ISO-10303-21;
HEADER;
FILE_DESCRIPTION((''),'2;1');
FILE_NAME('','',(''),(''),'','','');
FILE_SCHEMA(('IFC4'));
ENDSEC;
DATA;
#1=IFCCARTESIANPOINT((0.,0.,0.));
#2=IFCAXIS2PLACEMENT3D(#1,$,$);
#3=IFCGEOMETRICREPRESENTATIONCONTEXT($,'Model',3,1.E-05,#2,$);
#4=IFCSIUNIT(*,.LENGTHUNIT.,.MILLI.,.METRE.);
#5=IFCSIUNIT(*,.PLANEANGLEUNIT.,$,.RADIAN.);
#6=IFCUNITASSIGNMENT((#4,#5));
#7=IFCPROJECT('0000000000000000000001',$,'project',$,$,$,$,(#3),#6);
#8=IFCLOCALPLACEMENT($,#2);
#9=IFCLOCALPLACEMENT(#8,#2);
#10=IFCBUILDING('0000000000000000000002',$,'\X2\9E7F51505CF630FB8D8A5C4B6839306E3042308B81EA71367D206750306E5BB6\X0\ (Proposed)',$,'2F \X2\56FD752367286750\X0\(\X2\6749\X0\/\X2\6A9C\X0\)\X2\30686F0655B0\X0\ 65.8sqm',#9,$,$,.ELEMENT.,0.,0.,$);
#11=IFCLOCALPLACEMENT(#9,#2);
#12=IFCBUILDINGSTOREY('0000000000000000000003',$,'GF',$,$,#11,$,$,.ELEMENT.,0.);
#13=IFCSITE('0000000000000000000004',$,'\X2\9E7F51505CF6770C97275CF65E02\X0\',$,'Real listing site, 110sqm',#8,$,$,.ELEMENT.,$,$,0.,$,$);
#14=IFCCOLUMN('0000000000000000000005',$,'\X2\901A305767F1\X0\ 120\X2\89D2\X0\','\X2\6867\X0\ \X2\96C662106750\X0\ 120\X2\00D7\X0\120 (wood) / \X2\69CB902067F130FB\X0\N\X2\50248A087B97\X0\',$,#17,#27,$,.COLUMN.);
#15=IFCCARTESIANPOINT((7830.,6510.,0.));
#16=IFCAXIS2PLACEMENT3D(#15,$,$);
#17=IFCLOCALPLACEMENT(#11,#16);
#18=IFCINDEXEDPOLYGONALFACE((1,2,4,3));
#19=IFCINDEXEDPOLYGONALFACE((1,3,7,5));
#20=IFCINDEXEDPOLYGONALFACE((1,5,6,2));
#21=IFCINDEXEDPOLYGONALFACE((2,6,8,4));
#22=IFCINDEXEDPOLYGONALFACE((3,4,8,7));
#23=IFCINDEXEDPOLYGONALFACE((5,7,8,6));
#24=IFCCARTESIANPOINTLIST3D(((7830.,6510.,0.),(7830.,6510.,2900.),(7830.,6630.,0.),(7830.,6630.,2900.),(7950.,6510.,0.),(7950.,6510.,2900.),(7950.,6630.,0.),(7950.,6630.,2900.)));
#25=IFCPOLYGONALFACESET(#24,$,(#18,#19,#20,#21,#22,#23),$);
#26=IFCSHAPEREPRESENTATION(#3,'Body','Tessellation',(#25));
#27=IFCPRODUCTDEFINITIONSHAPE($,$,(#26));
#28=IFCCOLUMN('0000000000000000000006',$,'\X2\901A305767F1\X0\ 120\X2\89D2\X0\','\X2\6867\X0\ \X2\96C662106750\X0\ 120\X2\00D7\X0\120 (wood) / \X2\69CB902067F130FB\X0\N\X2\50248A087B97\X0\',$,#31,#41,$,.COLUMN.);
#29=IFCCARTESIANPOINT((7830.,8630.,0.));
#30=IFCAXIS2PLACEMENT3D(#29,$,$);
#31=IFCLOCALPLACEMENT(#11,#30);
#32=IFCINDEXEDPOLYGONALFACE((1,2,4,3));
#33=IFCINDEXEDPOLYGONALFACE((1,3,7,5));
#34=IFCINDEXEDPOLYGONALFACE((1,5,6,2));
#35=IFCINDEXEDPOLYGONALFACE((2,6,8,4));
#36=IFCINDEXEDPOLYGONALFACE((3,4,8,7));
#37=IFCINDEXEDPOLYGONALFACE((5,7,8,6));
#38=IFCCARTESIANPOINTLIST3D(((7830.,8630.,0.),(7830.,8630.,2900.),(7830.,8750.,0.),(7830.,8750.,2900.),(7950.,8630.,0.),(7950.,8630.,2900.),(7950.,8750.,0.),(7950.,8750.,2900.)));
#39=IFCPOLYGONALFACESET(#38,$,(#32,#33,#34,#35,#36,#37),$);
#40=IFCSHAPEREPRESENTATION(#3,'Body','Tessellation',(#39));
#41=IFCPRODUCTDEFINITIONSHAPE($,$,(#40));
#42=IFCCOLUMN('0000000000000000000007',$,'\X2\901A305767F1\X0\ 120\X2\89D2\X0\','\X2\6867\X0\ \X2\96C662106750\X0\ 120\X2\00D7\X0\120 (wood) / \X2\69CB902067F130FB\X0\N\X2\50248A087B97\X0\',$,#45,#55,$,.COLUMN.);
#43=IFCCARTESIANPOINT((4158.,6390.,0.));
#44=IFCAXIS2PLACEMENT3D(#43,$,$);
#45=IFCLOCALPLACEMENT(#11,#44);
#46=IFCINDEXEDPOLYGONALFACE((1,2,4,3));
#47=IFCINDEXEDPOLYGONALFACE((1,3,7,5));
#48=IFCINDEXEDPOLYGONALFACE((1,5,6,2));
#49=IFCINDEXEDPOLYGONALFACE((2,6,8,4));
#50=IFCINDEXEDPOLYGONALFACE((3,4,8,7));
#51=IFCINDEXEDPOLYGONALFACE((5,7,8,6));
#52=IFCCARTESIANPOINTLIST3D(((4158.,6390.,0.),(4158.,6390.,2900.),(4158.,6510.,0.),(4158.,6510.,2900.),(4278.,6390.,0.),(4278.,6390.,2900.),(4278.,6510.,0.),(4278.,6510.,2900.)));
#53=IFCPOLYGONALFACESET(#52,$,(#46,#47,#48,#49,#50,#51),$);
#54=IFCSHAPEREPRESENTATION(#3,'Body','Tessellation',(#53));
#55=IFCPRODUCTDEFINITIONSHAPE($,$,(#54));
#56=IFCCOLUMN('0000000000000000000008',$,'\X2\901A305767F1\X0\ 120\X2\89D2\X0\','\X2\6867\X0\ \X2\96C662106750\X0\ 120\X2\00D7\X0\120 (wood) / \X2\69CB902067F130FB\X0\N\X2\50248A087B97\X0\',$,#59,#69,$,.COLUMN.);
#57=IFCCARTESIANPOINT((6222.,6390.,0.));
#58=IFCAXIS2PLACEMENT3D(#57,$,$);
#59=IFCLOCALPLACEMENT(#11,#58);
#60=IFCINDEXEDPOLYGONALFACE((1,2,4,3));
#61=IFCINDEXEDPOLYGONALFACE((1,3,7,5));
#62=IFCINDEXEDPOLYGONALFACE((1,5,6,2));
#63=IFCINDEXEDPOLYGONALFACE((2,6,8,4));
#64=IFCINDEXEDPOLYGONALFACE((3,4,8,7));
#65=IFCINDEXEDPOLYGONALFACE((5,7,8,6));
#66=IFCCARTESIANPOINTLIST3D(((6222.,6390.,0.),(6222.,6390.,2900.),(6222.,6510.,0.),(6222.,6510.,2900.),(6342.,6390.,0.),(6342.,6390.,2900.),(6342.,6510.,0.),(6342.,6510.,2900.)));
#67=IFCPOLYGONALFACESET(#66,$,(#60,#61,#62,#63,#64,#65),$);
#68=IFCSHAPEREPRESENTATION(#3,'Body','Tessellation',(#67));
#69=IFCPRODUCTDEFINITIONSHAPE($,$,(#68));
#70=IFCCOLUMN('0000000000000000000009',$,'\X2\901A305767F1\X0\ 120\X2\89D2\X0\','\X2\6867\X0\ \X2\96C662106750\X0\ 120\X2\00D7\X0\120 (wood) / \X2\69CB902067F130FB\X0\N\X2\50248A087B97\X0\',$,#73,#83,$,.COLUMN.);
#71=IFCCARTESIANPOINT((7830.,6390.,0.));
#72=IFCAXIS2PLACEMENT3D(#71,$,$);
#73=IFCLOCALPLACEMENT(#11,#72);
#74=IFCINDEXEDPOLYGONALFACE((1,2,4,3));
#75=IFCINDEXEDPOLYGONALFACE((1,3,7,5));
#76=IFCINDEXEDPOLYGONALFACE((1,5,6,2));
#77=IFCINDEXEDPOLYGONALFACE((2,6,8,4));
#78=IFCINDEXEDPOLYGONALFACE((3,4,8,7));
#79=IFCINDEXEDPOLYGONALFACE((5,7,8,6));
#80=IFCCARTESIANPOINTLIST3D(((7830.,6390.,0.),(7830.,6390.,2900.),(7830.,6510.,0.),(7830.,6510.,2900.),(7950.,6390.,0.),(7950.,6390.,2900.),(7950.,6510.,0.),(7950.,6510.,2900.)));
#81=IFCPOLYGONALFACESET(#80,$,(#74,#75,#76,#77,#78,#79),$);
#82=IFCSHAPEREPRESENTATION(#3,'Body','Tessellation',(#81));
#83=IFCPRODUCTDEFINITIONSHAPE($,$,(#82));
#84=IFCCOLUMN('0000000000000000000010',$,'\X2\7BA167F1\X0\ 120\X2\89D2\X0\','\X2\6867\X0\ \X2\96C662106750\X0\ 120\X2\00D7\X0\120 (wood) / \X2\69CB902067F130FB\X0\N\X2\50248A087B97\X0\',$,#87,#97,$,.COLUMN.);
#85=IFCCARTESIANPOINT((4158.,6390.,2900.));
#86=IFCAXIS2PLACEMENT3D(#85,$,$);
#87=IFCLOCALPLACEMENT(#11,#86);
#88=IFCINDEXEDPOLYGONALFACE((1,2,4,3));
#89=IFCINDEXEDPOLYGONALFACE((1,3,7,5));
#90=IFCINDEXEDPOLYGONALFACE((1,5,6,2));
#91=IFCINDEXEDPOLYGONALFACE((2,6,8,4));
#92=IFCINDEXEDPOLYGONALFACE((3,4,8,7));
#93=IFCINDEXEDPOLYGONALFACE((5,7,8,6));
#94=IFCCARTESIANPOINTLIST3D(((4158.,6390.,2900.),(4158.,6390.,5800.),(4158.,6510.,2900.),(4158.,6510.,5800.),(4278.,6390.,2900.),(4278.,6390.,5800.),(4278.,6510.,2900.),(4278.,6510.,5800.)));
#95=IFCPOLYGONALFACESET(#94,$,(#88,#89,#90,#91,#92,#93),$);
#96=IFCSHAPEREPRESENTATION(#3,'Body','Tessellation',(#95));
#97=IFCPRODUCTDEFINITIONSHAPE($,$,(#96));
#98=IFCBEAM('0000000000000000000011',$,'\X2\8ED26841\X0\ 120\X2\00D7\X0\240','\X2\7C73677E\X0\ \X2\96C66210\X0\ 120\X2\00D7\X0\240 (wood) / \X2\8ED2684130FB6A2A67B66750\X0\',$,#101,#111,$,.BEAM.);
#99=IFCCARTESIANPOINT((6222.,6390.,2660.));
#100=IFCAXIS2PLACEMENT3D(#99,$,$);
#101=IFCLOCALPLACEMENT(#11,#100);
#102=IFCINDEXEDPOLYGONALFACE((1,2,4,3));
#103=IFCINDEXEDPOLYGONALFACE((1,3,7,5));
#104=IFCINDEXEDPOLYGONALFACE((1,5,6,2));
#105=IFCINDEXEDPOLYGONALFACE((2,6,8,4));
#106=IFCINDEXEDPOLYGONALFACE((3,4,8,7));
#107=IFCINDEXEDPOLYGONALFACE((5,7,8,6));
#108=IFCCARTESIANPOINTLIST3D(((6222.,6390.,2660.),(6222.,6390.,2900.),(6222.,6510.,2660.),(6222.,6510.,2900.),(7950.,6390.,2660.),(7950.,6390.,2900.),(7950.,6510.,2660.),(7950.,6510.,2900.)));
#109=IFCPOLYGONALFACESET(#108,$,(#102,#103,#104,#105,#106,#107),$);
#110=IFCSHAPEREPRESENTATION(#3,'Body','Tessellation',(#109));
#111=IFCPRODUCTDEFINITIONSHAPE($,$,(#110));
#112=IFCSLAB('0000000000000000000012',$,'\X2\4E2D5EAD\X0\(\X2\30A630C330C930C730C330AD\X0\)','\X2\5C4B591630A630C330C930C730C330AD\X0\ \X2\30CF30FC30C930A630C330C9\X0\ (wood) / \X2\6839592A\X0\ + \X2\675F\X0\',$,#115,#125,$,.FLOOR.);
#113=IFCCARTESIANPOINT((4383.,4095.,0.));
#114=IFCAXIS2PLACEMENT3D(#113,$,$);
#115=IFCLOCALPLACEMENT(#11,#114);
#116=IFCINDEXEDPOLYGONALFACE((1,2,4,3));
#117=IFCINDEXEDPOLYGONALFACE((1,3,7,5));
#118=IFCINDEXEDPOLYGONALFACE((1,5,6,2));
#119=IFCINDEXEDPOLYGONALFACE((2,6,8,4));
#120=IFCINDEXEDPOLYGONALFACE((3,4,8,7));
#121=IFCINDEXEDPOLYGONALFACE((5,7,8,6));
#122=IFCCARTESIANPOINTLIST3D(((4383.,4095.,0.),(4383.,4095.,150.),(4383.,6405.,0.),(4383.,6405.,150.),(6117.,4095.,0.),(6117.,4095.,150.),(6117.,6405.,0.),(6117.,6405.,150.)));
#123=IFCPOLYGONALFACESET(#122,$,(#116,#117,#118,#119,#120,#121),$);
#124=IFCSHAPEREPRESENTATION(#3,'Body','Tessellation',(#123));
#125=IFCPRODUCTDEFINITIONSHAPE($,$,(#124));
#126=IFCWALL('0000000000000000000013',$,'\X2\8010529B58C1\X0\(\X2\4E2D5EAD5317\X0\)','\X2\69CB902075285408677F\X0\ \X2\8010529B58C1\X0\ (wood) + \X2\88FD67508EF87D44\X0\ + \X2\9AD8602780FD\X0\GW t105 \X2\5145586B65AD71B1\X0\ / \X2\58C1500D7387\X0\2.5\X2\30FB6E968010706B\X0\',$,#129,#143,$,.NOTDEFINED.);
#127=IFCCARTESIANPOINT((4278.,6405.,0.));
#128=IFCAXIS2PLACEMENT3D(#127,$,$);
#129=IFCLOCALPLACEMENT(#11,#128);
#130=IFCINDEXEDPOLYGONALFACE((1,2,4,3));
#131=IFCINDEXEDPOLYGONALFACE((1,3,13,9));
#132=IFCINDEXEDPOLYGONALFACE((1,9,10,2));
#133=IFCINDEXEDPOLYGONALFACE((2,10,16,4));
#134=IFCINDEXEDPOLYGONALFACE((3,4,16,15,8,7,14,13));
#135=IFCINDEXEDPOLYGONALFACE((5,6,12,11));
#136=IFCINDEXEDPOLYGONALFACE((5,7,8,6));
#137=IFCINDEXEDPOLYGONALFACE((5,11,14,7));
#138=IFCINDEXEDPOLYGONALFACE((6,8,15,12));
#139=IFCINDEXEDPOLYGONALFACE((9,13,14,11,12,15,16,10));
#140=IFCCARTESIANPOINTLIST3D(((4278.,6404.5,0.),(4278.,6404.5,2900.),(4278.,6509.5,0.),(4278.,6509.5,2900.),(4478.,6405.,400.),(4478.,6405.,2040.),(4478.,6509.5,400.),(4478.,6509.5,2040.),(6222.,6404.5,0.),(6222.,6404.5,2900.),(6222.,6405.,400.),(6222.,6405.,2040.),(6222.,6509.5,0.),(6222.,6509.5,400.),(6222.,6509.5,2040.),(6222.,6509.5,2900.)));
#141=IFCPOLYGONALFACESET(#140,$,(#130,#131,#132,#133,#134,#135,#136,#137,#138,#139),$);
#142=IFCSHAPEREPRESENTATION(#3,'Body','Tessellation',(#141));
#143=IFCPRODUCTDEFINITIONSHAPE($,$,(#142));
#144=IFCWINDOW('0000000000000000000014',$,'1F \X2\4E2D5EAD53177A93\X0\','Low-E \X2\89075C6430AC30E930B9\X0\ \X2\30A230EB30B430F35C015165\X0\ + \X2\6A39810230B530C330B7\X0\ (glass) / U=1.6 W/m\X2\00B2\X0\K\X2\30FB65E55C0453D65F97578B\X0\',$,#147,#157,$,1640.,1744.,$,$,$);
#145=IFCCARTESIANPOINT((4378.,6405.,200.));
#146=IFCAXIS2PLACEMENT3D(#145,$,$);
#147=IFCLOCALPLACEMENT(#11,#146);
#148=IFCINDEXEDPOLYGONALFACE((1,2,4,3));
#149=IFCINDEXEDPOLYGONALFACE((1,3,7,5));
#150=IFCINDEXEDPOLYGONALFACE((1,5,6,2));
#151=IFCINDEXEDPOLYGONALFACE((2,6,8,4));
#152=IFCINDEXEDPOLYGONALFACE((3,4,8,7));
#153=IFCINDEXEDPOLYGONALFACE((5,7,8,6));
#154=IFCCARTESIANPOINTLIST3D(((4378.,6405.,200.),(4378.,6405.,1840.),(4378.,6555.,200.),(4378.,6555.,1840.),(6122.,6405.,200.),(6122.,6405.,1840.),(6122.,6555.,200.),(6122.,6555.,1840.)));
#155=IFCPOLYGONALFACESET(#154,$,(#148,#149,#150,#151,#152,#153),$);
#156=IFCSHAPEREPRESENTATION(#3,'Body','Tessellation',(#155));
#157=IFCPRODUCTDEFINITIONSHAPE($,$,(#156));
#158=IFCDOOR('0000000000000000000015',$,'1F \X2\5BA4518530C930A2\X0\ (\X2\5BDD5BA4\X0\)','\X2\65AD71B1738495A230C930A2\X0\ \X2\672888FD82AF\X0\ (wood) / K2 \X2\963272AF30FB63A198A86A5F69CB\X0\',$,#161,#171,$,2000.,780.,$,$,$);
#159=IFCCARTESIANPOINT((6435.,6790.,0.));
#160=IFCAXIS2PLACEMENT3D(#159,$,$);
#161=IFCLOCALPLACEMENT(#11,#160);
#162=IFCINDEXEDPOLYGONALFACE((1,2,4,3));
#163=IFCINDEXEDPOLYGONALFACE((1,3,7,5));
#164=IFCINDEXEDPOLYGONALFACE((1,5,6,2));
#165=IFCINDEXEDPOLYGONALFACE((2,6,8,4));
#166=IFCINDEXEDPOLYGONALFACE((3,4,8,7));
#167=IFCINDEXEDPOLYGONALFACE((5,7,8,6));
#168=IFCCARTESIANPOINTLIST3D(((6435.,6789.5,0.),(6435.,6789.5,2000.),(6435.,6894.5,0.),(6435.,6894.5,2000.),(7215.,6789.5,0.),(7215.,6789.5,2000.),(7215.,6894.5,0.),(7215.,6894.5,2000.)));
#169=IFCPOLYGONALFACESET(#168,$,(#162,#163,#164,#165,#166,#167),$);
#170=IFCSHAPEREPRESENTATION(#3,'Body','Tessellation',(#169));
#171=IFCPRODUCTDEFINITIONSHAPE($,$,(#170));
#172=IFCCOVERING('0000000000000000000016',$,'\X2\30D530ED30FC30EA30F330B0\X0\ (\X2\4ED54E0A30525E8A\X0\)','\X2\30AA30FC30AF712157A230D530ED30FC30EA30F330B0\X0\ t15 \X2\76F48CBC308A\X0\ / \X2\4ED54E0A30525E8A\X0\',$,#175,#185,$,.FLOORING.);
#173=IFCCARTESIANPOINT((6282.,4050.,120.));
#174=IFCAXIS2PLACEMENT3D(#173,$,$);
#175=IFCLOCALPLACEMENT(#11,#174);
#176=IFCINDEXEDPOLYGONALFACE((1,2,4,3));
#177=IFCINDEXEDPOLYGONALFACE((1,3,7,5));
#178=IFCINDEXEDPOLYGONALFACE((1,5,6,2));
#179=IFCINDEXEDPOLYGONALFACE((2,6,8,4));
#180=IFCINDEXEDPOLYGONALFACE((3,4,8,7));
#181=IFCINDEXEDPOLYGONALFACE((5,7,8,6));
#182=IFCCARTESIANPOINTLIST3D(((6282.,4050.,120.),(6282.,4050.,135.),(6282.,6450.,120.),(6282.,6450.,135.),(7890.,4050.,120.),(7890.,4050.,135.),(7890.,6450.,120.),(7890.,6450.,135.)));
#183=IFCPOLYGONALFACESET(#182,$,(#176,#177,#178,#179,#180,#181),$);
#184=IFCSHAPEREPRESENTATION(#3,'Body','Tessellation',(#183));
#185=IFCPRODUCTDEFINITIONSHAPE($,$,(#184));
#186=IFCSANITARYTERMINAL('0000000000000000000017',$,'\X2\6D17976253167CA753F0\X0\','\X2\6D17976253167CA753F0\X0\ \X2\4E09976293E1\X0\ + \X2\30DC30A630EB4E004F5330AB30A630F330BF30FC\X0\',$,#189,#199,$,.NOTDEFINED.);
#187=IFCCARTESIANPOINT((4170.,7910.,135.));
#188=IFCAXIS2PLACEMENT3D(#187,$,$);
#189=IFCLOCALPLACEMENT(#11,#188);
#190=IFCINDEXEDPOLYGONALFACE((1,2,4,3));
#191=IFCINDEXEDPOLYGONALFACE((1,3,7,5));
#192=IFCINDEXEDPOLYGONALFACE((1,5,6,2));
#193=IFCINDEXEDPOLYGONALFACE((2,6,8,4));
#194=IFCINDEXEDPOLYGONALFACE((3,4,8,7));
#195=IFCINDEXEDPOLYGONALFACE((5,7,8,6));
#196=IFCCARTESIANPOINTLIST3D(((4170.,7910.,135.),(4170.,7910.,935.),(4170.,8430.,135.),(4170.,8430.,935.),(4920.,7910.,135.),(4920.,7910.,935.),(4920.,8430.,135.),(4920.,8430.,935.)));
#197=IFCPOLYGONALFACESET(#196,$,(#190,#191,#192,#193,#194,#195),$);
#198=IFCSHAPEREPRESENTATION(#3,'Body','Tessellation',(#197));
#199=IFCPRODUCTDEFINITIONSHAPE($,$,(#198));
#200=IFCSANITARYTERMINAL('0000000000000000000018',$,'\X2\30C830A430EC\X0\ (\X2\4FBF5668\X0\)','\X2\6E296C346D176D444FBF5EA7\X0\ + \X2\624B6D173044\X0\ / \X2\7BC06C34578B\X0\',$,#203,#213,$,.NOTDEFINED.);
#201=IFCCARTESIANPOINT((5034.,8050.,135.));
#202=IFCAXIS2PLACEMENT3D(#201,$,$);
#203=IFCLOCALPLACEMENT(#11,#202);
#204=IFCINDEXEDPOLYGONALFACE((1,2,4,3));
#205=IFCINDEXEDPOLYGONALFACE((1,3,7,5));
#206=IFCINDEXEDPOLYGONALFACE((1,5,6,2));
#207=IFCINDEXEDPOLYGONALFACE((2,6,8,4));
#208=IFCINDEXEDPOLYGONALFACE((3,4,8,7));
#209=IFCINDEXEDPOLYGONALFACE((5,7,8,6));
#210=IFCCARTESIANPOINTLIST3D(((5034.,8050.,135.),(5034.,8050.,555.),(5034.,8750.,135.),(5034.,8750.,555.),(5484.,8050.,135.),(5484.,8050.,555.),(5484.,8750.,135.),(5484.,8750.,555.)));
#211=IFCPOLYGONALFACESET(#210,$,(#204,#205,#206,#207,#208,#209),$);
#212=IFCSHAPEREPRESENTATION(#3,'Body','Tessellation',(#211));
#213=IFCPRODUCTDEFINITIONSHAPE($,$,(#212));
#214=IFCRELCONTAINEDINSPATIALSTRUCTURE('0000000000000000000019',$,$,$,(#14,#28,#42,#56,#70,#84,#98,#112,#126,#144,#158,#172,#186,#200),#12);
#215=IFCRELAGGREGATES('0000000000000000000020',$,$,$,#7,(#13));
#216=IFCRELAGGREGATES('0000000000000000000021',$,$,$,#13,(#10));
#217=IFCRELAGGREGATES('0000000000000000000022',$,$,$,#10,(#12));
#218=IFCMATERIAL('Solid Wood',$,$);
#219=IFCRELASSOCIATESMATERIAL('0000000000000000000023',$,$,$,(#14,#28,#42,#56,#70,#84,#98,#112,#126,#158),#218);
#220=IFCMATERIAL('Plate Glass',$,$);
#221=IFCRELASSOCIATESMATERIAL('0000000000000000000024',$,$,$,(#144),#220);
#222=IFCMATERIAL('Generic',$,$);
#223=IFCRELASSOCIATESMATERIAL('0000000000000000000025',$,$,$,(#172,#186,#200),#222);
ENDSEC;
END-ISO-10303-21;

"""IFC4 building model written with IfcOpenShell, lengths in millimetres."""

from ifc_helpers import new_model, si_unit, frame, frame_2d, origin, place, context, project, spatial, rectangle, extrude, material, element, fill, save


model = new_model("IFC4")

# Units and contexts
model_context = context("Model", 3, precision=1e-05, world=origin())
ifc_project = project(units=[si_unit("LENGTHUNIT", "METRE", prefix="MILLI"), si_unit("PLANEANGLEUNIT", "RADIAN")], contexts=[model_context])

# Site, building, storey
site_placement = place(None, origin())
site = spatial("IfcSite", under=ifc_project, at=site_placement, Name="鹿児島県霧島市", ObjectType="Real listing site, 110sqm", CompositionType="ELEMENT", RefElevation=0.0)
building_placement = place(site_placement, origin())
building = spatial("IfcBuilding", under=site, at=building_placement, Name="鹿児島・越屋根のある自然素材の家 (Proposed)", ObjectType="2F 国産木材(杉/檜)と漆喰 65.8sqm", CompositionType="ELEMENT", ElevationOfRefHeight=0.0, ElevationOfTerrain=0.0)
storey_placement = place(building_placement, origin())
storey = spatial("IfcBuildingStorey", under=building, at=storey_placement, Name="GF", CompositionType="ELEMENT", Elevation=0.0)

# Columns
ifc_material_1 = material(Name="Solid Wood")
column_1_placement = place(storey_placement, frame((7830.0, 6510.0, 0.0)))
element("IfcColumn", 1, at=column_1_placement, inside=storey, material=ifc_material_1, Name="通し柱 120角", Description="桧 集成材 120×120 (wood) / 構造柱・N値計算", PredefinedType="COLUMN", context=model_context, shape_type="SweptSolid", body=[
    extrude(rectangle(XDim=120.0, YDim=120.0, at=frame_2d((60.0, 60.0))), frame((7830.0, 6510.0, 0.0)), (0.0, 0.0, 1.0), 2900.0),
])
column_2_placement = place(storey_placement, frame((7830.0, 8630.0, 0.0)))
element("IfcColumn", 2, at=column_2_placement, inside=storey, material=ifc_material_1, Name="通し柱 120角", Description="桧 集成材 120×120 (wood) / 構造柱・N値計算", PredefinedType="COLUMN", context=model_context, shape_type="SweptSolid", body=[
    extrude(rectangle(XDim=120.0, YDim=120.0, at=frame_2d((60.0, 60.0))), frame((7830.0, 8630.0, 0.0)), (0.0, 0.0, 1.0), 2900.0),
])
column_3_placement = place(storey_placement, frame((4158.0, 6390.0, 0.0)))
element("IfcColumn", 3, at=column_3_placement, inside=storey, material=ifc_material_1, Name="通し柱 120角", Description="桧 集成材 120×120 (wood) / 構造柱・N値計算", PredefinedType="COLUMN", context=model_context, shape_type="SweptSolid", body=[
    extrude(rectangle(XDim=120.0, YDim=120.0, at=frame_2d((60.0, 60.0))), frame((4158.0, 6390.0, 0.0)), (0.0, 0.0, 1.0), 2900.0),
])
column_4_placement = place(storey_placement, frame((6222.0, 6390.0, 0.0)))
element("IfcColumn", 4, at=column_4_placement, inside=storey, material=ifc_material_1, Name="通し柱 120角", Description="桧 集成材 120×120 (wood) / 構造柱・N値計算", PredefinedType="COLUMN", context=model_context, shape_type="SweptSolid", body=[
    extrude(rectangle(XDim=120.0, YDim=120.0, at=frame_2d((60.0, 60.0))), frame((6222.0, 6390.0, 0.0)), (0.0, 0.0, 1.0), 2900.0),
])
column_5_placement = place(storey_placement, frame((7830.0, 6390.0, 0.0)))
element("IfcColumn", 5, at=column_5_placement, inside=storey, material=ifc_material_1, Name="通し柱 120角", Description="桧 集成材 120×120 (wood) / 構造柱・N値計算", PredefinedType="COLUMN", context=model_context, shape_type="SweptSolid", body=[
    extrude(rectangle(XDim=120.0, YDim=120.0, at=frame_2d((60.0, 60.0))), frame((7830.0, 6390.0, 0.0)), (0.0, 0.0, 1.0), 2900.0),
])
column_6_placement = place(storey_placement, frame((4158.0, 6390.0, 2900.0)))
element("IfcColumn", 6, at=column_6_placement, inside=storey, material=ifc_material_1, Name="管柱 120角", Description="桧 集成材 120×120 (wood) / 構造柱・N値計算", PredefinedType="COLUMN", context=model_context, shape_type="SweptSolid", body=[
    extrude(rectangle(XDim=120.0, YDim=120.0, at=frame_2d((60.0, 60.0))), frame((4158.0, 6390.0, 2900.0)), (0.0, 0.0, 1.0), 2900.0),
])

# Beam
beam_1_placement = place(storey_placement, frame((6222.0, 6390.0, 2660.0)))
element("IfcBeam", 7, at=beam_1_placement, inside=storey, material=ifc_material_1, Name="軒桁 120×240", Description="米松 集成 120×240 (wood) / 軒桁・横架材", PredefinedType="BEAM", context=model_context, shape_type="SweptSolid", body=[
    extrude(rectangle(XDim=1728.0, YDim=120.0, at=frame_2d((864.0, 60.0))), frame((6222.0, 6390.0, 2660.0)), (0.0, 0.0, 1.0), 240.0),
])

# Slab
slab_placement = place(storey_placement, frame((4383.0, 4095.0, 0.0)))
element("IfcSlab", 8, at=slab_placement, inside=storey, material=ifc_material_1, Name="中庭(ウッドデッキ)", Description="屋外ウッドデッキ ハードウッド (wood) / 根太 + 束", PredefinedType="FLOOR", context=model_context, shape_type="SweptSolid", body=[
    extrude(rectangle(XDim=1734.0, YDim=2310.0, at=frame_2d((867.0, 1155.0))), frame((4383.0, 4095.0, 0.0)), (0.0, 0.0, 1.0), 150.0),
])

# Wall, opening, window
wall_1_placement = place(storey_placement, frame((4278.0, 6405.0, 0.0)))
wall_1 = element("IfcWall", 9, at=wall_1_placement, inside=storey, material=ifc_material_1, Name="耐力壁(中庭北)", Description="構造用合板 耐力壁 (wood) + 製材軸組 + 高性能GW t105 充填断熱 / 壁倍率2.5・準耐火", PredefinedType="NOTDEFINED", context=model_context, shape_type="SweptSolid", body=[
    extrude(rectangle(XDim=1944.0, YDim=105.0, at=frame_2d((972.0, 52.0))), frame((4278.0, 6405.0, 0.0)), (0.0, 0.0, 1.0), 2900.0),
])
opening_placement = place(storey_placement, frame((4378.0, 6405.0, 200.0)))
opening = element("IfcOpeningElement", 10, at=opening_placement, cuts=wall_1, PredefinedType="NOTDEFINED", context=model_context, shape_type="SweptSolid", body=[
    extrude(rectangle(XDim=1744.0, YDim=150.0, at=frame_2d((872.0, 75.0))), frame((4378.0, 6405.0, 200.0)), (0.0, 0.0, 1.0), 1640.0),
])
ifc_material_2 = material(Name="Plate Glass")
window_placement = place(storey_placement, frame((4378.0, 6405.0, 200.0)))
window = element("IfcWindow", 11, at=window_placement, inside=storey, material=ifc_material_2, Name="1F 中庭北窓", Description="Low-E 複層ガラス アルゴン封入 + 樹脂サッシ (glass) / U=1.6 W/m²K・日射取得型", OverallHeight=1640.0, OverallWidth=1744.0, context=model_context, shape_type="SweptSolid", body=[
    extrude(rectangle(XDim=1744.0, YDim=150.0, at=frame_2d((872.0, 75.0))), frame((4378.0, 6405.0, 200.0)), (0.0, 0.0, 1.0), 1640.0),
])
fill(opening, window)

# Door
door_placement = place(storey_placement, frame((6435.0, 6790.0, 0.0)))
element("IfcDoor", 12, at=door_placement, inside=storey, material=ifc_material_1, Name="1F 室内ドア (寝室)", Description="断熱玄関ドア 木製芯 (wood) / K2 防犯・採風機構", OverallHeight=2000.0, OverallWidth=780.0, context=model_context, shape_type="SweptSolid", body=[
    extrude(rectangle(XDim=780.0, YDim=105.0, at=frame_2d((390.0, 52.0))), frame((6435.0, 6790.0, 0.0)), (0.0, 0.0, 1.0), 2000.0),
])

# Covering
ifc_material_3 = material(Name="Generic")
covering_placement = place(storey_placement, frame((6282.0, 4050.0, 120.0)))
element("IfcCovering", 13, at=covering_placement, inside=storey, material=ifc_material_3, Name="フローリング (仕上げ床)", Description="オーク無垢フローリング t15 直貼り / 仕上げ床", PredefinedType="FLOORING", context=model_context, shape_type="SweptSolid", body=[
    extrude(rectangle(XDim=1608.0, YDim=2400.0, at=frame_2d((804.0, 1200.0))), frame((6282.0, 4050.0, 120.0)), (0.0, 0.0, 1.0), 15.0),
])

# Sanitary terminals
sanitary_terminal_1_placement = place(storey_placement, frame((4170.0, 7910.0, 135.0)))
element("IfcSanitaryTerminal", 14, at=sanitary_terminal_1_placement, inside=storey, material=ifc_material_3, Name="洗面化粧台", Description="洗面化粧台 三面鏡 + ボウル一体カウンター", PredefinedType="NOTDEFINED", context=model_context, shape_type="SweptSolid", body=[
    extrude(rectangle(XDim=750.0, YDim=520.0, at=frame_2d((375.0, 260.0))), frame((4170.0, 7910.0, 135.0)), (0.0, 0.0, 1.0), 800.0),
])
sanitary_terminal_2_placement = place(storey_placement, frame((5034.0, 8050.0, 135.0)))
element("IfcSanitaryTerminal", 15, at=sanitary_terminal_2_placement, inside=storey, material=ifc_material_3, Name="トイレ (便器)", Description="温水洗浄便座 + 手洗い / 節水型", PredefinedType="NOTDEFINED", context=model_context, shape_type="SweptSolid", body=[
    extrude(rectangle(XDim=450.0, YDim=700.0, at=frame_2d((225.0, 350.0))), frame((5034.0, 8050.0, 135.0)), (0.0, 0.0, 1.0), 420.0),
])

save(model, "model.ifc")
